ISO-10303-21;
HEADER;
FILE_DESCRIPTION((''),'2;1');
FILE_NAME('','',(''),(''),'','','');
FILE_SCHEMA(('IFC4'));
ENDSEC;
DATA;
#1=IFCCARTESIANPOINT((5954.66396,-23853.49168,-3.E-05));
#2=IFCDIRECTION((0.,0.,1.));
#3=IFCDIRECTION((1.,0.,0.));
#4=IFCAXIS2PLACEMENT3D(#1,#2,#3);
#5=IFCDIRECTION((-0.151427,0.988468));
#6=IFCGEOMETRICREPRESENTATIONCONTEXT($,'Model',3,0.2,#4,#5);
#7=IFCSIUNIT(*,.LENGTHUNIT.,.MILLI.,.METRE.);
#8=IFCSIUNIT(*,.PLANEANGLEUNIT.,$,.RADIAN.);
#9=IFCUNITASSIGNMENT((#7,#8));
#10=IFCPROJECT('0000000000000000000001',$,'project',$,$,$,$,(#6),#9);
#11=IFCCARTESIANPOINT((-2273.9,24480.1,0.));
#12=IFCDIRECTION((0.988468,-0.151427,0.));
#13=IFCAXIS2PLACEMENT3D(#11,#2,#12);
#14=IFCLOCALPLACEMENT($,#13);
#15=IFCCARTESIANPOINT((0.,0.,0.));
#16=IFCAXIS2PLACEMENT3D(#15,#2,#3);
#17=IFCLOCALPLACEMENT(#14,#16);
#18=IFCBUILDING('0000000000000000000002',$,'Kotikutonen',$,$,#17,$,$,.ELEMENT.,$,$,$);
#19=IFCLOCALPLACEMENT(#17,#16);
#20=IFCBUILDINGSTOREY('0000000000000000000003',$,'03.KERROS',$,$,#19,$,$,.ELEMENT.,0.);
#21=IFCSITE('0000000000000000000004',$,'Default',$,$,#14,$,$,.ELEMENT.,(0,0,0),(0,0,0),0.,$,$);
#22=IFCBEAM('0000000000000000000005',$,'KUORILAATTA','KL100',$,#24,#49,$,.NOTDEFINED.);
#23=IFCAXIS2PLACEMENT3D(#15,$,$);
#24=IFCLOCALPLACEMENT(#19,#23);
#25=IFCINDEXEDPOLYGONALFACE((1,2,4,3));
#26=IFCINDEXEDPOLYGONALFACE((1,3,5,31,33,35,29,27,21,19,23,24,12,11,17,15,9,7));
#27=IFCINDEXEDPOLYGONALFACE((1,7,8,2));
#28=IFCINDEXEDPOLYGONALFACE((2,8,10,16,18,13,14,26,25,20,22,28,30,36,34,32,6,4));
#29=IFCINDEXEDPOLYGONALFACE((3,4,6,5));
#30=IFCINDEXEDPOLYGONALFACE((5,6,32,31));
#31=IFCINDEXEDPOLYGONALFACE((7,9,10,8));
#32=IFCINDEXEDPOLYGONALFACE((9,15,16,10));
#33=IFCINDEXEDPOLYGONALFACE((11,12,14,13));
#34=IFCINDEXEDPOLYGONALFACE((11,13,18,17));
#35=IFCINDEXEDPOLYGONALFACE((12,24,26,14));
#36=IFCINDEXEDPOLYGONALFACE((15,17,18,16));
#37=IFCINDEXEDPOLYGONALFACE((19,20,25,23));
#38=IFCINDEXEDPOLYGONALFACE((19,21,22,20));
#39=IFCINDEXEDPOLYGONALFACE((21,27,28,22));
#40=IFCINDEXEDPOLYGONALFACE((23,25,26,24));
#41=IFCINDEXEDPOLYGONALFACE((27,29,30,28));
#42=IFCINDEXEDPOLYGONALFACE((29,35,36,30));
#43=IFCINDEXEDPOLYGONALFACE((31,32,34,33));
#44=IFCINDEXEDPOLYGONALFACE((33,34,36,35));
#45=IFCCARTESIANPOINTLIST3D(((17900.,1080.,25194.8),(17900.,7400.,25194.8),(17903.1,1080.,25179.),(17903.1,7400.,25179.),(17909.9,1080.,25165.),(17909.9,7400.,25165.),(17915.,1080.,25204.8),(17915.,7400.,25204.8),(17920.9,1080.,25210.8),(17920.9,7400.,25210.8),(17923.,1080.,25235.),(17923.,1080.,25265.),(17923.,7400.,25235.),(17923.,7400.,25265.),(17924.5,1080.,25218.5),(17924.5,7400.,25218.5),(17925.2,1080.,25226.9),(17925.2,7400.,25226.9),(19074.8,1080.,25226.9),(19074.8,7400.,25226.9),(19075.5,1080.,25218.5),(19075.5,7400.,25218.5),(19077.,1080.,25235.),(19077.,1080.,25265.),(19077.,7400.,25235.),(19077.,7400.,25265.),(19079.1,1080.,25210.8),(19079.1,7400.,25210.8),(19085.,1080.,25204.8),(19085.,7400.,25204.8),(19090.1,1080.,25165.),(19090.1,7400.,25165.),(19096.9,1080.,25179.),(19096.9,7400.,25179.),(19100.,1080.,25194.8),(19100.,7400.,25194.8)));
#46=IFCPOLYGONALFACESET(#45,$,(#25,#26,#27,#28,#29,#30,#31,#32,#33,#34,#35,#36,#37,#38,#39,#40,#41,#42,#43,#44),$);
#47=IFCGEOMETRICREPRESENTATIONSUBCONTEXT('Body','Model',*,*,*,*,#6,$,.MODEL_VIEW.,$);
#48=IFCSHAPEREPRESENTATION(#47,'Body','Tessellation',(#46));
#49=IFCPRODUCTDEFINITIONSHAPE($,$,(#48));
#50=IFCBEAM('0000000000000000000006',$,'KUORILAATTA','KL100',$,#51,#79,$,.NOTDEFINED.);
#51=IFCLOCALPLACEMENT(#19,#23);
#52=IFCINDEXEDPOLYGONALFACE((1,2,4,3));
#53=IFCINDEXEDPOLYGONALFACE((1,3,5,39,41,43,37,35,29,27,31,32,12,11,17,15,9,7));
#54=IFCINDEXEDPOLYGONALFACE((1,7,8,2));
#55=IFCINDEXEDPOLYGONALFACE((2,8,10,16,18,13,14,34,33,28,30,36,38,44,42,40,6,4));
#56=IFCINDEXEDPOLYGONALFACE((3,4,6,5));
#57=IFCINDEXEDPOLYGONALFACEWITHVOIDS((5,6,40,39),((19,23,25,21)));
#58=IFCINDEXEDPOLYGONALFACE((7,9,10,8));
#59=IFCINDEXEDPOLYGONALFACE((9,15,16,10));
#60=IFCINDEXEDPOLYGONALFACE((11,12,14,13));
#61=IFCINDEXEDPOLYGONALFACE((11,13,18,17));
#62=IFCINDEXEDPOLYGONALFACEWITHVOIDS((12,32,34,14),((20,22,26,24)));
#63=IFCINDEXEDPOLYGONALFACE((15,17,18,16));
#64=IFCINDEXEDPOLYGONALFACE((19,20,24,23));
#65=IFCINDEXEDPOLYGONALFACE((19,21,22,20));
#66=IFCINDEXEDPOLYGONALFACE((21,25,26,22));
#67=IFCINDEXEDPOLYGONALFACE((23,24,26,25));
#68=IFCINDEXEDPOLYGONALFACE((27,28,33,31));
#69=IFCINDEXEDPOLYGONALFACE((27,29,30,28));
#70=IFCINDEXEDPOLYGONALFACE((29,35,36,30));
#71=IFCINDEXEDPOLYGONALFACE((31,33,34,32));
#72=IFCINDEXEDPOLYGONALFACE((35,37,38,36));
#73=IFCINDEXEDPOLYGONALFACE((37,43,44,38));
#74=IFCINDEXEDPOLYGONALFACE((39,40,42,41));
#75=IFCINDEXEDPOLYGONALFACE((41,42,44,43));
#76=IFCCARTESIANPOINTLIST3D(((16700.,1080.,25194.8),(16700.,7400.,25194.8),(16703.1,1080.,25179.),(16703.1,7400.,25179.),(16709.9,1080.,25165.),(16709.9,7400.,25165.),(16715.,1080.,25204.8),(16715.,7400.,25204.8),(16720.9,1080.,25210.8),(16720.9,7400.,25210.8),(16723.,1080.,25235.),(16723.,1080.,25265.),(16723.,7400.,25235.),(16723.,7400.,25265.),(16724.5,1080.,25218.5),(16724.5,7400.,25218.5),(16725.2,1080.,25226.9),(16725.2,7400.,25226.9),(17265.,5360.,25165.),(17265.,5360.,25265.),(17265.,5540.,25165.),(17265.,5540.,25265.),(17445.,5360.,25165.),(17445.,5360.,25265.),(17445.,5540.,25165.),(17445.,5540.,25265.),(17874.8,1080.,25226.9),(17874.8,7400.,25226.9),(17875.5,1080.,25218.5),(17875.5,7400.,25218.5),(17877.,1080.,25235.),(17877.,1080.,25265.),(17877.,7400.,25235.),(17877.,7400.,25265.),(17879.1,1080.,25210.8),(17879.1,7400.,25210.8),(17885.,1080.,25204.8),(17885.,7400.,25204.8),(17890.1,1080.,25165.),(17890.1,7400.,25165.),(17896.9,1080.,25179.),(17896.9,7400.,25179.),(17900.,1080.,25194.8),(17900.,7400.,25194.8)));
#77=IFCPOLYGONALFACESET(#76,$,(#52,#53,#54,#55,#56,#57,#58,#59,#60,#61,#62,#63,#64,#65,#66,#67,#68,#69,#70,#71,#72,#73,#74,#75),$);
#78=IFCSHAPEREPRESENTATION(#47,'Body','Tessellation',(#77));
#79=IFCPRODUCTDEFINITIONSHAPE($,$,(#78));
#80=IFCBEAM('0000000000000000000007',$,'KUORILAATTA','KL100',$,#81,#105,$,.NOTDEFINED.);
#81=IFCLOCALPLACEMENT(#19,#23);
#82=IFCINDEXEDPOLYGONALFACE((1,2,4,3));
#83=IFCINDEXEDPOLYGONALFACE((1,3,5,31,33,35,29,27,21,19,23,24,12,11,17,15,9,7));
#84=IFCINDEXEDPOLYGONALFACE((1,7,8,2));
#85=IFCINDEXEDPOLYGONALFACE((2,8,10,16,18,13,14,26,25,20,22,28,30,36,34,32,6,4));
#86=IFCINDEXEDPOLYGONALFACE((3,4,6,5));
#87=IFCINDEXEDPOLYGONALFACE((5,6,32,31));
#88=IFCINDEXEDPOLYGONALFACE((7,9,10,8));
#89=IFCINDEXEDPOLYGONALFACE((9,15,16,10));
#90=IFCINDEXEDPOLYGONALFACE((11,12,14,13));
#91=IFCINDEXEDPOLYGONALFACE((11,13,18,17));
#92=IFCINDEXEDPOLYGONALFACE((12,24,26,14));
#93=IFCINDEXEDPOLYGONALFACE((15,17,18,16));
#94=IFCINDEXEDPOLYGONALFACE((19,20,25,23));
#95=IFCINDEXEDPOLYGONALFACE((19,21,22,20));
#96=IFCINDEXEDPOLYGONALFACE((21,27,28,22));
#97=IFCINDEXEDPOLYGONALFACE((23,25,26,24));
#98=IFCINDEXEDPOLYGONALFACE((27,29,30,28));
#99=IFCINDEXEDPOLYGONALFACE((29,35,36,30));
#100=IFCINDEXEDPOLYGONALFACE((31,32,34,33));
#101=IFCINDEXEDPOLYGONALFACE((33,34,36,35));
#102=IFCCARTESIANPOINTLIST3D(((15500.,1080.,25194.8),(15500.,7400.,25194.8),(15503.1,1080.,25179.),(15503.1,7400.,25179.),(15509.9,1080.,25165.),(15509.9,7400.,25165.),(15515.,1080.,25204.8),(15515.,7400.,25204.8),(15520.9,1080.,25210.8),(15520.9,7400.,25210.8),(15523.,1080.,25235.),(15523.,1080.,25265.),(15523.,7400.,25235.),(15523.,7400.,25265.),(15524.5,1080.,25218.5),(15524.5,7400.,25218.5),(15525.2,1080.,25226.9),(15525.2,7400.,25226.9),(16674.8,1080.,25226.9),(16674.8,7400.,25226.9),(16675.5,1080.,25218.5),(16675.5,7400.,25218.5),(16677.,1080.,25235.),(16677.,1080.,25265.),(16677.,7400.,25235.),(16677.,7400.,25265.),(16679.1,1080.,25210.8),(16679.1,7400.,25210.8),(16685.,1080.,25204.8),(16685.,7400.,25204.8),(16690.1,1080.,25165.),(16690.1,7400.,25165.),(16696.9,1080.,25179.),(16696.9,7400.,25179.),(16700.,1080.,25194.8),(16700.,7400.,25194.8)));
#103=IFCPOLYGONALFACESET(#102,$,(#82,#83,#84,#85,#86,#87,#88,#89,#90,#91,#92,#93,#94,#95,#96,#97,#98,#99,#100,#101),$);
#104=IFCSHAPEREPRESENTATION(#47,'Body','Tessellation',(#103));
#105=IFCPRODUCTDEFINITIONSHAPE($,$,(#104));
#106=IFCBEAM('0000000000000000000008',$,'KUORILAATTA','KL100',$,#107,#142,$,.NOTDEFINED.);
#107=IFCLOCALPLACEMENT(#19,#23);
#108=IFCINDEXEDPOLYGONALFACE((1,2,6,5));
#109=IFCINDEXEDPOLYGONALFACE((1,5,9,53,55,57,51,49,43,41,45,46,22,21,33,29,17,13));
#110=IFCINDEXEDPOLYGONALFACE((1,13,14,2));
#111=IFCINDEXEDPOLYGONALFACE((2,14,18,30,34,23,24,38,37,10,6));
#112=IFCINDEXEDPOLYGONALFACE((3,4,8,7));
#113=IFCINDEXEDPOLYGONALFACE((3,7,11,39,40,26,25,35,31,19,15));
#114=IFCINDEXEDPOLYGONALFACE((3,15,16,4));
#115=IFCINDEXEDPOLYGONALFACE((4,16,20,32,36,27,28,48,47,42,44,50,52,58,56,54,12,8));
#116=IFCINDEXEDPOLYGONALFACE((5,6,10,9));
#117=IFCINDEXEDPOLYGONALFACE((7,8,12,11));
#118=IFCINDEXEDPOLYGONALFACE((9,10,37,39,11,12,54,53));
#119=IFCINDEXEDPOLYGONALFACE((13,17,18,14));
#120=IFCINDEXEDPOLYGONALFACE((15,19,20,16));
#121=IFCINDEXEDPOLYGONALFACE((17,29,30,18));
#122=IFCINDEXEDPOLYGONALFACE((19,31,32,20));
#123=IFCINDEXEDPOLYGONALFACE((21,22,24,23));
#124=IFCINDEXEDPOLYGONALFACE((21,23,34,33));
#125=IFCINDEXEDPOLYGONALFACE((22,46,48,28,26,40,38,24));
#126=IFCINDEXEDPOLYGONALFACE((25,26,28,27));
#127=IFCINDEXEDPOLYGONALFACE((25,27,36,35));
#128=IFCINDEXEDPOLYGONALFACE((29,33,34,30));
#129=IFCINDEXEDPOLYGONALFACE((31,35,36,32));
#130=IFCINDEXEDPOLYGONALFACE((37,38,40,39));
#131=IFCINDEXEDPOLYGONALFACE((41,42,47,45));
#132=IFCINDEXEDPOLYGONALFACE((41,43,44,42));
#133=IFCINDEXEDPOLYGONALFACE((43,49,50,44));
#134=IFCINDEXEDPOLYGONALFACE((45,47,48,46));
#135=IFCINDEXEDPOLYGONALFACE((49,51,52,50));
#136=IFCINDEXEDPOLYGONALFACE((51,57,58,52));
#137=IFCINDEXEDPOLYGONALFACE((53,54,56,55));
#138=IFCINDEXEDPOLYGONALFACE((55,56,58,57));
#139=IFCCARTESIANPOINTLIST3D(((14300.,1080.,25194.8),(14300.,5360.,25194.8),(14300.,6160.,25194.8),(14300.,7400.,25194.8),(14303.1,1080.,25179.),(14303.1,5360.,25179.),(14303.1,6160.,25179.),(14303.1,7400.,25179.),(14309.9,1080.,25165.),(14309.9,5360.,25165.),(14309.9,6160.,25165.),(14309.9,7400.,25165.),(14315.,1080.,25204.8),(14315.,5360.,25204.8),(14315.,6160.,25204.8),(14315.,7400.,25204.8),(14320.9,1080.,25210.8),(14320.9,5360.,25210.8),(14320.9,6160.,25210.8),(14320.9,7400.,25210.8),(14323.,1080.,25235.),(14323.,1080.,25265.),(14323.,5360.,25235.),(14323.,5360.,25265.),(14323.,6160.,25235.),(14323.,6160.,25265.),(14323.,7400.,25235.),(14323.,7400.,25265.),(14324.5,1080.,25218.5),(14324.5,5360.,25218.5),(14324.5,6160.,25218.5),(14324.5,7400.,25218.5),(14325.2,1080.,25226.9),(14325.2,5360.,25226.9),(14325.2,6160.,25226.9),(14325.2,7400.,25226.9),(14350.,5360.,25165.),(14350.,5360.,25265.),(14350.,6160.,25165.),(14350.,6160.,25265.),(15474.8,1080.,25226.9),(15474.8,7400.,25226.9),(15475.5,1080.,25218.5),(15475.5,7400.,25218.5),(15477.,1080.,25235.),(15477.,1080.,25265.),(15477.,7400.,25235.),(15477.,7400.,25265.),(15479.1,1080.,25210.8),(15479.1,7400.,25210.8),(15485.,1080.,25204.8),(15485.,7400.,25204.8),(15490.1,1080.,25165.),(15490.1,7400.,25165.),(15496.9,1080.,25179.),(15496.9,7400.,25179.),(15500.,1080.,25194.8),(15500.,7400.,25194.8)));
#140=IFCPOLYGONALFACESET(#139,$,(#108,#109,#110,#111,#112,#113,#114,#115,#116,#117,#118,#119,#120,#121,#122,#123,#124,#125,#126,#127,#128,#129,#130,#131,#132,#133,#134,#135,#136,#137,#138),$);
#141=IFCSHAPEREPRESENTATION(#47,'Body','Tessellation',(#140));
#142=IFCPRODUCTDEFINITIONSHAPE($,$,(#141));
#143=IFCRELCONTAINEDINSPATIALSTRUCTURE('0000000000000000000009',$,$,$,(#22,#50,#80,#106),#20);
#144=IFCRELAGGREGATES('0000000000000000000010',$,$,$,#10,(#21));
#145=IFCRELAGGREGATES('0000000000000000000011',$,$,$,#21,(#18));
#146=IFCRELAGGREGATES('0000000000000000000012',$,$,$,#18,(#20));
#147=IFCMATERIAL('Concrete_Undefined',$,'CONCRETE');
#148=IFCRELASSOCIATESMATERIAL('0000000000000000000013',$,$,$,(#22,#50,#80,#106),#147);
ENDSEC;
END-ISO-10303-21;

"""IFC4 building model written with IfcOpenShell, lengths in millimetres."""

from ifc_helpers import new_model, si_unit, direction, frame, origin_with_axes, place, context, subcontext, project, spatial, line, indexed_curve, outline, extrude, material, element, save


model = new_model("IFC4")

# Units and contexts
model_context = context("Model", 3, precision=0.2, world=frame((5954.66396, -23853.49168, -3e-05), z_axis=(0.0, 0.0, 1.0), x_axis=(1.0, 0.0, 0.0)), true_north=direction((-0.151427, 0.988468)))
body_context = subcontext(model_context, "Body", "Model", "MODEL_VIEW")
ifc_project = project(units=[si_unit("LENGTHUNIT", "METRE", prefix="MILLI"), si_unit("PLANEANGLEUNIT", "RADIAN")], contexts=[model_context])

# Site, building, storey
site_placement = place(None, frame((-2273.9, 24480.1, 0.0), z_axis=(0.0, 0.0, 1.0), x_axis=(0.988468, -0.151427, 0.0)))
site = spatial("IfcSite", under=ifc_project, at=site_placement, Name="Default", CompositionType="ELEMENT", RefLatitude=(0, 0, 0), RefLongitude=(0, 0, 0), RefElevation=0.0)
building_placement = place(site_placement, origin_with_axes())
building = spatial("IfcBuilding", under=site, at=building_placement, Name="Kotikutonen", CompositionType="ELEMENT")
storey_placement = place(building_placement, origin_with_axes())
storey = spatial("IfcBuildingStorey", under=building, at=storey_placement, Name="03.KERROS", CompositionType="ELEMENT", Elevation=0.0)

# Beam
ifc_material_1 = material(Name="Concrete_Undefined", Category="CONCRETE")
beam_1_placement = place(storey_placement, frame((18500.0, 7400.0, 25215.0), z_axis=(-1.0, 0.0, 0.0), x_axis=(0.0, -1.0, 0.0)))
element("IfcBeam", 1, at=beam_1_placement, inside=storey, material=ifc_material_1, Name="KUORILAATTA", Description="KL100", PredefinedType="NOTDEFINED", context=body_context, shape_type="SolidModel", body=[
    extrude(outline(indexed_curve([(-596.9, -36.0), (-590.1, -50.0), (590.1, -50.0), (596.9, -36.0), (600.0, -20.2), (585.0, -10.2), (579.1, -4.2), (575.5, 3.5), (574.8, 11.9), (577.0, 20.0), (577.0, 50.0), (-577.0, 50.0), (-577.0, 20.0), (-574.8, 11.9), (-575.5, 3.5), (-579.1, -4.2), (-585.0, -10.2), (-600.0, -20.2)], segments=[line(1, 2, 3, 4, 5, 6, 7, 8, 9, 10, 11, 12, 13, 14, 15, 16, 17, 18, 1)])), frame((0.0, 0.0, 0.0), z_axis=(-1.0, 0.0, 0.0), x_axis=(0.0, 0.0, 1.0)), (0.0, 0.0, -1.0), 6320.0),
])

# Beam, voiding feature
beam_2_placement = place(storey_placement, frame((17300.0, 7400.0, 25215.0), z_axis=(-1.0, 0.0, 0.0), x_axis=(0.0, -1.0, 0.0)))
beam_2 = element("IfcBeam", 2, at=beam_2_placement, inside=storey, material=ifc_material_1, Name="KUORILAATTA", Description="KL100", PredefinedType="NOTDEFINED", context=body_context, shape_type="SolidModel", body=[
    extrude(outline(indexed_curve([(-596.9, -36.0), (-590.1, -50.0), (590.1, -50.0), (596.9, -36.0), (600.0, -20.2), (585.0, -10.2), (579.1, -4.2), (575.5, 3.5), (574.8, 11.9), (577.0, 20.0), (577.0, 50.0), (-577.0, 50.0), (-577.0, 20.0), (-574.8, 11.9), (-575.5, 3.5), (-579.1, -4.2), (-585.0, -10.2), (-600.0, -20.2)], segments=[line(1, 2, 3, 4, 5, 6, 7, 8, 9, 10, 11, 12, 13, 14, 15, 16, 17, 18, 1)])), frame((0.0, 0.0, 0.0), z_axis=(-1.0, 0.0, 0.0), x_axis=(0.0, 0.0, 1.0)), (0.0, 0.0, -1.0), 6320.0),
])
voiding_feature_1_placement = place(beam_2_placement, frame((1860.0, 0.0, -145.0), z_axis=(0.0, 1.0, 0.0), x_axis=(0.0, 0.0, 1.0)))
element("IfcVoidingFeature", 3, at=voiding_feature_1_placement, cuts=beam_2, Name="Opening", PredefinedType="HOLE", context=body_context, shape_type="SolidModel", body=[
    extrude(outline(indexed_curve([(0.0, 0.0), (180.0, 0.0), (180.0, 180.0), (0.0, 180.0)], segments=[line(1, 2, 3, 4, 1)])), frame((0.0, 0.0, 125.0), z_axis=(0.0, 0.0, 1.0), x_axis=(1.0, 0.0, 0.0)), (0.0, 0.0, -1.0), 250.0),
])

# Beam
beam_3_placement = place(storey_placement, frame((16100.0, 7400.0, 25215.0), z_axis=(-1.0, 0.0, 0.0), x_axis=(0.0, -1.0, 0.0)))
element("IfcBeam", 4, at=beam_3_placement, inside=storey, material=ifc_material_1, Name="KUORILAATTA", Description="KL100", PredefinedType="NOTDEFINED", context=body_context, shape_type="SolidModel", body=[
    extrude(outline(indexed_curve([(-596.9, -36.0), (-590.1, -50.0), (590.1, -50.0), (596.9, -36.0), (600.0, -20.2), (585.0, -10.2), (579.1, -4.2), (575.5, 3.5), (574.8, 11.9), (577.0, 20.0), (577.0, 50.0), (-577.0, 50.0), (-577.0, 20.0), (-574.8, 11.9), (-575.5, 3.5), (-579.1, -4.2), (-585.0, -10.2), (-600.0, -20.2)], segments=[line(1, 2, 3, 4, 5, 6, 7, 8, 9, 10, 11, 12, 13, 14, 15, 16, 17, 18, 1)])), frame((0.0, 0.0, 0.0), z_axis=(-1.0, 0.0, 0.0), x_axis=(0.0, 0.0, 1.0)), (0.0, 0.0, -1.0), 6320.0),
])

# Beam, voiding feature
beam_4_placement = place(storey_placement, frame((14900.0, 7400.0, 25215.0), z_axis=(-1.0, 0.0, 0.0), x_axis=(0.0, -1.0, 0.0)))
beam_4 = element("IfcBeam", 5, at=beam_4_placement, inside=storey, material=ifc_material_1, Name="KUORILAATTA", Description="KL100", PredefinedType="NOTDEFINED", context=body_context, shape_type="SolidModel", body=[
    extrude(outline(indexed_curve([(-596.9, -36.0), (-590.1, -50.0), (590.1, -50.0), (596.9, -36.0), (600.0, -20.2), (585.0, -10.2), (579.1, -4.2), (575.5, 3.5), (574.8, 11.9), (577.0, 20.0), (577.0, 50.0), (-577.0, 50.0), (-577.0, 20.0), (-574.8, 11.9), (-575.5, 3.5), (-579.1, -4.2), (-585.0, -10.2), (-600.0, -20.2)], segments=[line(1, 2, 3, 4, 5, 6, 7, 8, 9, 10, 11, 12, 13, 14, 15, 16, 17, 18, 1)])), frame((0.0, 0.0, 0.0), z_axis=(-1.0, 0.0, 0.0), x_axis=(0.0, 0.0, 1.0)), (0.0, 0.0, -1.0), 6320.0),
])
voiding_feature_2_placement = place(beam_4_placement, frame((1240.0, 0.0, 550.0), z_axis=(0.0, 1.0, 0.0), x_axis=(0.0, 0.0, 1.0)))
element("IfcVoidingFeature", 6, at=voiding_feature_2_placement, cuts=beam_4, Name="Opening", PredefinedType="HOLE", context=body_context, shape_type="SolidModel", body=[
    extrude(outline(indexed_curve([(0.0, 0.0), (300.0, 0.0), (300.0, 800.0), (0.0, 800.0)], segments=[line(1, 2, 3, 4, 1)])), frame((0.0, 0.0, 125.0), z_axis=(0.0, 0.0, 1.0), x_axis=(1.0, 0.0, 0.0)), (0.0, 0.0, -1.0), 250.0),
])

save(model, "model.ifc")
